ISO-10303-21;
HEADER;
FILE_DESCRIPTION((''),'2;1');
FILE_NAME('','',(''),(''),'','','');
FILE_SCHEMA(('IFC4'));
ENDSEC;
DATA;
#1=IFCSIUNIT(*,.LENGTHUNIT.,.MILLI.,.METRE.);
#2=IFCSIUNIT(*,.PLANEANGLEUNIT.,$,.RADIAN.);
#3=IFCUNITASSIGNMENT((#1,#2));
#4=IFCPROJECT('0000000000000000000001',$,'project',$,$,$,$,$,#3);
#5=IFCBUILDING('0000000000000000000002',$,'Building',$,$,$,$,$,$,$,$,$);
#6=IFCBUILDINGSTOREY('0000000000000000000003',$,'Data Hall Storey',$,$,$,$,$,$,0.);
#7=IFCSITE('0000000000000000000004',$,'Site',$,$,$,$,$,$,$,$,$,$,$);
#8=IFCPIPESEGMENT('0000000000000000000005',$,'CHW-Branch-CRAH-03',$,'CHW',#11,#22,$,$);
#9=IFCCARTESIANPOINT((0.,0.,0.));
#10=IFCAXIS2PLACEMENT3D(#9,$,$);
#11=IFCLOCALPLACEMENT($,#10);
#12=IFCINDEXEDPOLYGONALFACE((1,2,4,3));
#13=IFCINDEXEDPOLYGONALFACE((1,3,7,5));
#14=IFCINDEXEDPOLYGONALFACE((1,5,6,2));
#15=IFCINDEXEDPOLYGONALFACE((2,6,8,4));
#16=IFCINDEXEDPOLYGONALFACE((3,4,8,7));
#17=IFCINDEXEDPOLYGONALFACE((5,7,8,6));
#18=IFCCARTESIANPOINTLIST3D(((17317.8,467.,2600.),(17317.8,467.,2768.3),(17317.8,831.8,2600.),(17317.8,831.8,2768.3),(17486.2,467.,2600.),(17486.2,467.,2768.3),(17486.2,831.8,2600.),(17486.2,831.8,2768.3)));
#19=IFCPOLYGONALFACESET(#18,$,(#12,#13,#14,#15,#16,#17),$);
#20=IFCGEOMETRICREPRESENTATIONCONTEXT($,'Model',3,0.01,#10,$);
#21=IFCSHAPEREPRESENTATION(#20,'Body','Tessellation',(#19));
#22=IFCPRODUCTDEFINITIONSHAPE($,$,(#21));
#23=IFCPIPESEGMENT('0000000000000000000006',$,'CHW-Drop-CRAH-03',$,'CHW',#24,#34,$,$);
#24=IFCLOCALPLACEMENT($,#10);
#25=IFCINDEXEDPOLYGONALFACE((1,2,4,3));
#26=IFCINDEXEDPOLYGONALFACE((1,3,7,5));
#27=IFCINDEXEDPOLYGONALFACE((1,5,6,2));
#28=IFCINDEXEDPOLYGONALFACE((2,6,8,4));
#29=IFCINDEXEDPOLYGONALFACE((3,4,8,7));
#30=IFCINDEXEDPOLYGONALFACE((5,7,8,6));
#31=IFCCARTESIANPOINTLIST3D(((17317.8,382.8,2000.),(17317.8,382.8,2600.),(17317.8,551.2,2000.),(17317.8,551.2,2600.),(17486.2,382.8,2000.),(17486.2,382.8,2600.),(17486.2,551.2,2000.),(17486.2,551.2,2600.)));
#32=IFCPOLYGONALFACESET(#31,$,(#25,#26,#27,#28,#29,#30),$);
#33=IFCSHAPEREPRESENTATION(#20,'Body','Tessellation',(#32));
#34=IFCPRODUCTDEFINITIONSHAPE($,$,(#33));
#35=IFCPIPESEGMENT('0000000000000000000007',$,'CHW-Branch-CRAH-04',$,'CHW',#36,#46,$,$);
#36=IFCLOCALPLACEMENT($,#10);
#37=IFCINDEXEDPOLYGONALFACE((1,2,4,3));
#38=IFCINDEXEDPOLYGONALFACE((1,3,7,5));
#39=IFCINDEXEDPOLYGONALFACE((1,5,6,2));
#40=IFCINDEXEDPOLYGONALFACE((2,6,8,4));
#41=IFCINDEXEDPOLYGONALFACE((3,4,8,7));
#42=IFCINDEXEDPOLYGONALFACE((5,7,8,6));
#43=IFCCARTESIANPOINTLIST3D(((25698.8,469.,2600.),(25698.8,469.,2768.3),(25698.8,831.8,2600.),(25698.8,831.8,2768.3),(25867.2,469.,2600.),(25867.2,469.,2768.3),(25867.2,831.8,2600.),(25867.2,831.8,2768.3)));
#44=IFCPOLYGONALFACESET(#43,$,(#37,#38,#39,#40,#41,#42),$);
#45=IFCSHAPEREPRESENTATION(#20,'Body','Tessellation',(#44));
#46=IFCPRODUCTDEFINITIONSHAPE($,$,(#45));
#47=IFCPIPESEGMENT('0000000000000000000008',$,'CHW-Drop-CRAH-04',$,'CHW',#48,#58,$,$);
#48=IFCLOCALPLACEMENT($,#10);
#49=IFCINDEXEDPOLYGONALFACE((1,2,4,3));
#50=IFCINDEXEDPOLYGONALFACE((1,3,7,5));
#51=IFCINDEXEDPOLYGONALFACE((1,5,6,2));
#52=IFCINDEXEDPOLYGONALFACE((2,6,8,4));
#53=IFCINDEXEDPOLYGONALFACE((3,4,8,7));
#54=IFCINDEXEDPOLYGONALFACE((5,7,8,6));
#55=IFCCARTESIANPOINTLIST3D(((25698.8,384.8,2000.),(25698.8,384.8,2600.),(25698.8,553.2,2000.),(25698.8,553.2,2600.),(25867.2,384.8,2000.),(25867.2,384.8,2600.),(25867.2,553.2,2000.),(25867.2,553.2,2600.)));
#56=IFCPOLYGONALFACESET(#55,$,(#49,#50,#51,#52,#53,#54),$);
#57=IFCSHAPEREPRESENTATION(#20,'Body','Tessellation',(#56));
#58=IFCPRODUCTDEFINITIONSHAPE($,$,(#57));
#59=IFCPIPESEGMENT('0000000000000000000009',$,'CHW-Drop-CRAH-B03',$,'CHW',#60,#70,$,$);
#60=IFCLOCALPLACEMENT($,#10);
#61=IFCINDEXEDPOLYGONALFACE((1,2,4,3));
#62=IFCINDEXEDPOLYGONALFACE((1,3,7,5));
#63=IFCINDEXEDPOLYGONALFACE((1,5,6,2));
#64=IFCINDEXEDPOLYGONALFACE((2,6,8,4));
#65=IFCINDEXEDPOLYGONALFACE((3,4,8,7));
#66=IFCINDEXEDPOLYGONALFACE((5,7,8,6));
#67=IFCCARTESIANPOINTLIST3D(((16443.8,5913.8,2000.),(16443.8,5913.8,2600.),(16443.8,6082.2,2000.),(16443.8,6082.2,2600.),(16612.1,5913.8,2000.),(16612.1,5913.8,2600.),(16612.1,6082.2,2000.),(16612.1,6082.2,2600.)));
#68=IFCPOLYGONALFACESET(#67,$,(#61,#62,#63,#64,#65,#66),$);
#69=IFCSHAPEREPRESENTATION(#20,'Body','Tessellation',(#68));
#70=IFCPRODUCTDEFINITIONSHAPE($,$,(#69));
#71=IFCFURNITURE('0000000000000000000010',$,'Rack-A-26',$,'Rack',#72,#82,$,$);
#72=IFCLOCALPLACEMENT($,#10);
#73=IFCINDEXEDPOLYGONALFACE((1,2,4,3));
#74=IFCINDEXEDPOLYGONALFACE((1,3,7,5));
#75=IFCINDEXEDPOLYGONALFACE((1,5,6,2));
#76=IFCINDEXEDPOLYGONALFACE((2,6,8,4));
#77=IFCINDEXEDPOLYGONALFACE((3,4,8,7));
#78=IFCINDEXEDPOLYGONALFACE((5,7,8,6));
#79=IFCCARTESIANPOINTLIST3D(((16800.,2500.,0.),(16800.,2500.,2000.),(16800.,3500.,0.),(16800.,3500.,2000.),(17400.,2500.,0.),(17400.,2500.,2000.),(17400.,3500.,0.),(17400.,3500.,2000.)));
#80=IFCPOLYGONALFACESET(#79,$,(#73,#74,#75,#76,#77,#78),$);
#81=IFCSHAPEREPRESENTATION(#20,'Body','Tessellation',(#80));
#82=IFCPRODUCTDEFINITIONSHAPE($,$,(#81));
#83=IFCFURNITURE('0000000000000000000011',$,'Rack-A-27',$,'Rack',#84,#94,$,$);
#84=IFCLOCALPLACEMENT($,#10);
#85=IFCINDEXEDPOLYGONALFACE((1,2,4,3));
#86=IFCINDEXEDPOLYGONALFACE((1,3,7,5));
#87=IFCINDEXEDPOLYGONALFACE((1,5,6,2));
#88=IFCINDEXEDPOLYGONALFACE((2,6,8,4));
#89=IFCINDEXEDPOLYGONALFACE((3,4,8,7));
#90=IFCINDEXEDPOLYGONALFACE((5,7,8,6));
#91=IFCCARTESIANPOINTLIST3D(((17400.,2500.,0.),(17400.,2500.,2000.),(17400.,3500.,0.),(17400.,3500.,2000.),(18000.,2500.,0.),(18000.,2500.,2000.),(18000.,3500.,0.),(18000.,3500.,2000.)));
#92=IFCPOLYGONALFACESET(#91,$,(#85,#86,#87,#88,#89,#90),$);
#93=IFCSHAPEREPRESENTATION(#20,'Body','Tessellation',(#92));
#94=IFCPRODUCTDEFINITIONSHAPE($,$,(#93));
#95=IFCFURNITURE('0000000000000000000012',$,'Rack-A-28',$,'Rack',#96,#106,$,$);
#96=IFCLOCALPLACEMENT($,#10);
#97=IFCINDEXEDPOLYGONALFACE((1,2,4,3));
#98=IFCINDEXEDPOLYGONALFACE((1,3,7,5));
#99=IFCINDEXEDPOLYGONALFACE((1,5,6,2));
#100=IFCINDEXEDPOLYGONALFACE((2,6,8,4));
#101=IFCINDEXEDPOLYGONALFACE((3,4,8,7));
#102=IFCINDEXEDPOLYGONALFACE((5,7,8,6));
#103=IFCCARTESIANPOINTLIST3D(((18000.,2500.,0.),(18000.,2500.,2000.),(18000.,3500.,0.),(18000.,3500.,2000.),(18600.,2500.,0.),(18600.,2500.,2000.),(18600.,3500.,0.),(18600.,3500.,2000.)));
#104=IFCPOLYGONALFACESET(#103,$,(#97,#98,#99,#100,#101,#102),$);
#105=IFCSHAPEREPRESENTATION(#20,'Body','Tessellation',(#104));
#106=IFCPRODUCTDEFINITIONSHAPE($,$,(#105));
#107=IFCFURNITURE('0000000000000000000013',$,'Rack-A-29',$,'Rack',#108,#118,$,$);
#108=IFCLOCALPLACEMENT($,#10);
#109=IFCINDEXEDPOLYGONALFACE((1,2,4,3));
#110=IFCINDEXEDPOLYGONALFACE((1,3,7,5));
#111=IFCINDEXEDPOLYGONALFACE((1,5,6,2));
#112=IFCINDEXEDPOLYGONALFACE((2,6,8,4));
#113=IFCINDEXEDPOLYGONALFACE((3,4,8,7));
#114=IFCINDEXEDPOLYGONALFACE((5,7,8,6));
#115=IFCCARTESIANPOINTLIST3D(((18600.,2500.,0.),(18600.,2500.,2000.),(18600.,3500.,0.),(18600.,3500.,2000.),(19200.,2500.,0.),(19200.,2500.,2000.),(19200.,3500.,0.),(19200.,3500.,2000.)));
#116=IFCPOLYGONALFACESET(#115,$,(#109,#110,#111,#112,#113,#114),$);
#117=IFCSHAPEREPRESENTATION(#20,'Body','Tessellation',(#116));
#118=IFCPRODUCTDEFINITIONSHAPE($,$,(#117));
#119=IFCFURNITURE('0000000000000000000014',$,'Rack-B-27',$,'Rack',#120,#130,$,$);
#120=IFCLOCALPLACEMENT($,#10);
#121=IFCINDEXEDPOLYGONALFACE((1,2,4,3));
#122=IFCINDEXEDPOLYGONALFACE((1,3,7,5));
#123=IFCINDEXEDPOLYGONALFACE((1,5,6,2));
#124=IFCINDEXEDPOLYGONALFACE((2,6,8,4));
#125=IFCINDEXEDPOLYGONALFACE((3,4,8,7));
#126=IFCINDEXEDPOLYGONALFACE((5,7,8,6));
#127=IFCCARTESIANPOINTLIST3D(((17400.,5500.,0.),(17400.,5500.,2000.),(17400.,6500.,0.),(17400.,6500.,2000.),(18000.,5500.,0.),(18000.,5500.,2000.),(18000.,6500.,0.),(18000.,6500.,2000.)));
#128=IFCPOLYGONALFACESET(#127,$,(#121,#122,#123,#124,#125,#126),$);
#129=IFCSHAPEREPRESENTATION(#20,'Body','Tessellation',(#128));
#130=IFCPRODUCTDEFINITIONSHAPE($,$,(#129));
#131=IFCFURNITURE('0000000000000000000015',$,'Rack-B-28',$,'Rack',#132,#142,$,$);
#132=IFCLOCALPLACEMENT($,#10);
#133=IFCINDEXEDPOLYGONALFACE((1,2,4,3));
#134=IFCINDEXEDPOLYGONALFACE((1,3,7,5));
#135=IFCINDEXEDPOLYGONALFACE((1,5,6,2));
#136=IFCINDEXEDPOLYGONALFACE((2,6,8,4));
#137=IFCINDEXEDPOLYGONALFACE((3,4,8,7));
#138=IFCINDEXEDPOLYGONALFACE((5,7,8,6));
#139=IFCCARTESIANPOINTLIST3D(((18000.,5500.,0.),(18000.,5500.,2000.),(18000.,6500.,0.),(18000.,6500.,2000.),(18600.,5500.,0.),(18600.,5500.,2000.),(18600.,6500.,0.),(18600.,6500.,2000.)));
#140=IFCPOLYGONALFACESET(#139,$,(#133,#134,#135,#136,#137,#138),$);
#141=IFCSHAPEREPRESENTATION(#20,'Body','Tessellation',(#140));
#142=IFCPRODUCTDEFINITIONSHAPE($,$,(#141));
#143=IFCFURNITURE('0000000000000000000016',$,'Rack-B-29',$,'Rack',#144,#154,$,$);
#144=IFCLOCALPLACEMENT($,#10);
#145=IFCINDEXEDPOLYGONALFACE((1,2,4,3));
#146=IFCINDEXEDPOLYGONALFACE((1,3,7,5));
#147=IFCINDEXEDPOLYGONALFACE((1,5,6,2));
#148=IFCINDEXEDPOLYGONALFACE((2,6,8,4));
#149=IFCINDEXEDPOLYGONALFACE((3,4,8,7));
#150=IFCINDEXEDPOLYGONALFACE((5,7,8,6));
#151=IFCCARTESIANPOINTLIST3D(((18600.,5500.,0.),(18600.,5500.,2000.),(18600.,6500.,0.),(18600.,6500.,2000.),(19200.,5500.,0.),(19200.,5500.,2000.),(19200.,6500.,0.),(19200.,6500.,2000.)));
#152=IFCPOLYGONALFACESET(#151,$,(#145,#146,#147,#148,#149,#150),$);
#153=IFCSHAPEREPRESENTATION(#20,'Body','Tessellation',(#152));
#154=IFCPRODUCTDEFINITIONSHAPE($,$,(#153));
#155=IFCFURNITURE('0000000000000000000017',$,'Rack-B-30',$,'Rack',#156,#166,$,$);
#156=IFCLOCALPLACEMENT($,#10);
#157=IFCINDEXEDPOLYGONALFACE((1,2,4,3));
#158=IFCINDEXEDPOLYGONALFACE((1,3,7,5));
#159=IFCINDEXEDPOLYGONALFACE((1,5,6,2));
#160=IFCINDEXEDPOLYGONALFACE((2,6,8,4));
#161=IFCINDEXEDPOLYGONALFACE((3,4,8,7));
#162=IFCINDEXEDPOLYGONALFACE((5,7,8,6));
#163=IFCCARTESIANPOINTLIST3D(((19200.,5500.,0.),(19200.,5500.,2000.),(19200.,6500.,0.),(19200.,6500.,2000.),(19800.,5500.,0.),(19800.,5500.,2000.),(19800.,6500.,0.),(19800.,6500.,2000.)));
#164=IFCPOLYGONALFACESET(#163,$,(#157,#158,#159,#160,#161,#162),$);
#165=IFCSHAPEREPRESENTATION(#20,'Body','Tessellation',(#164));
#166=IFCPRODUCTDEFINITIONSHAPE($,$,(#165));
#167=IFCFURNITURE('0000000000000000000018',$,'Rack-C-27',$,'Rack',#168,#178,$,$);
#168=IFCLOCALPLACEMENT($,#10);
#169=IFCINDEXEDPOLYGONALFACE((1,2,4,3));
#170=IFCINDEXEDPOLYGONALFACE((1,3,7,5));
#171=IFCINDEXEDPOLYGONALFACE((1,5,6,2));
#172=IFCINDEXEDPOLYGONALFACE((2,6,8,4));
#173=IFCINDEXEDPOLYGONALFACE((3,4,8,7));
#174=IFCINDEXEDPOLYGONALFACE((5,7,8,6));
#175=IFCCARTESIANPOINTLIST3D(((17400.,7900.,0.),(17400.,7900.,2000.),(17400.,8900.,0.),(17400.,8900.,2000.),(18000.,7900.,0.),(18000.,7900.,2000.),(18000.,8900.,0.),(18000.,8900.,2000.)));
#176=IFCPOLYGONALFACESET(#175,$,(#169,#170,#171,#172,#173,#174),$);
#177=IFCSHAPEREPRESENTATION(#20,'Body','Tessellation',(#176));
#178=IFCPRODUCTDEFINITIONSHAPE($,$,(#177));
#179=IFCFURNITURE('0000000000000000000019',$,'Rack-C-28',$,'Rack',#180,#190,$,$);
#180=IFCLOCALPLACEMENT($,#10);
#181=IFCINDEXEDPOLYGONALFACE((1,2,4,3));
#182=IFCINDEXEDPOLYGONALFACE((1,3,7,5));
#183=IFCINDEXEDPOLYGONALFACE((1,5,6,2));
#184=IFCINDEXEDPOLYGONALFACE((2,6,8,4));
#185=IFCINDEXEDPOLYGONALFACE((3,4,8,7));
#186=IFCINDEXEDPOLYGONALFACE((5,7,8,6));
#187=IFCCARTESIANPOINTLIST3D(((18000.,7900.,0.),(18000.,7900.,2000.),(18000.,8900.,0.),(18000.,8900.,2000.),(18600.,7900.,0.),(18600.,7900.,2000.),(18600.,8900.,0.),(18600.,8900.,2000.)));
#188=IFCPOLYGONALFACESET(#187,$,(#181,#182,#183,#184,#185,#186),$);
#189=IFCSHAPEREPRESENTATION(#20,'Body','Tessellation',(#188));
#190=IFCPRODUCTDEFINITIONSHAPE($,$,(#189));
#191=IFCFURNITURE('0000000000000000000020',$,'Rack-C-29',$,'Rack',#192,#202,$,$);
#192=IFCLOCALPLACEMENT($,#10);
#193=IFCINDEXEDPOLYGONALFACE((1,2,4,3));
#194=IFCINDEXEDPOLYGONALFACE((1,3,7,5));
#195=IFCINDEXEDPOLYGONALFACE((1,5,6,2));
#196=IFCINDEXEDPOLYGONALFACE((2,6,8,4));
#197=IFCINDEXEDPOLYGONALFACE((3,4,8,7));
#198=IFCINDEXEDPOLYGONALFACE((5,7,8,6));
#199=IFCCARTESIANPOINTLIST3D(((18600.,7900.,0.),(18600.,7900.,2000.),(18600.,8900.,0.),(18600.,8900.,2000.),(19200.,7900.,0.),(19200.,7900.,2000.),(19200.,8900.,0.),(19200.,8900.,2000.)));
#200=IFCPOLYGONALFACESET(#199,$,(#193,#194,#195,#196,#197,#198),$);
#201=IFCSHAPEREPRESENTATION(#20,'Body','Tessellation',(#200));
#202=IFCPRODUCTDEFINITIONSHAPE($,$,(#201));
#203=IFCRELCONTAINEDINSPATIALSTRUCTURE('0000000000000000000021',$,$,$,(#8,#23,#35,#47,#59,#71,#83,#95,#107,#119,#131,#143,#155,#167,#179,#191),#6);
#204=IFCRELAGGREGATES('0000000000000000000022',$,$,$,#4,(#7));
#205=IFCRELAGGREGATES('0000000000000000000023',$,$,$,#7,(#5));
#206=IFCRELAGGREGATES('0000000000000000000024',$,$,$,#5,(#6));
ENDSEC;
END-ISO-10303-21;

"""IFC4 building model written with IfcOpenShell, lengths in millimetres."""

from ifc_helpers import new_model, si_unit, frame, origin, place, context, project, spatial, rectangle, extrude, element, save


model = new_model("IFC4")

# Units and contexts
model_context = context("Model", 3, precision=0.01, world=origin())
ifc_project = project(units=[si_unit("LENGTHUNIT", "METRE", prefix="MILLI"), si_unit("PLANEANGLEUNIT", "RADIAN")])

# Site, building, storey
site = spatial("IfcSite", under=ifc_project, Name="Site")
building = spatial("IfcBuilding", under=site, Name="Building")
storey = spatial("IfcBuildingStorey", under=building, Name="Data Hall Storey", Elevation=0.0)

# Pipe segments
pipe_segment_1_placement = place(None, frame((17402.0, 649.4, 2600.0)))
element("IfcPipeSegment", 1, at=pipe_segment_1_placement, inside=storey, Name="CHW-Branch-CRAH-03", ObjectType="CHW", context=model_context, shape_type="SweptSolid", body=[
    extrude(rectangle(XDim=168.3, YDim=364.9), origin(), (0.0, 0.0, 1.0), 168.3),
])
pipe_segment_2_placement = place(None, frame((17402.0, 467.0, 2000.0)))
element("IfcPipeSegment", 2, at=pipe_segment_2_placement, inside=storey, Name="CHW-Drop-CRAH-03", ObjectType="CHW", context=model_context, shape_type="SweptSolid", body=[
    extrude(rectangle(XDim=168.3, YDim=168.3), origin(), (0.0, 0.0, 1.0), 600.0),
])
pipe_segment_3_placement = place(None, frame((25783.0, 650.4, 2600.0)))
element("IfcPipeSegment", 3, at=pipe_segment_3_placement, inside=storey, Name="CHW-Branch-CRAH-04", ObjectType="CHW", context=model_context, shape_type="SweptSolid", body=[
    extrude(rectangle(XDim=168.3, YDim=362.9), origin(), (0.0, 0.0, 1.0), 168.3),
])
for number, where, name in (
    (4, (25783.0, 469.0, 2000.0), "CHW-Drop-CRAH-04"),
    (5, (16528.0, 5998.0, 2000.0), "CHW-Drop-CRAH-B03"),
):
    element("IfcPipeSegment", number, at=place(None, frame(where)), inside=storey, Name=name, ObjectType="CHW", context=model_context, shape_type="SweptSolid", body=[
        extrude(rectangle(XDim=168.3, YDim=168.3), origin(), (0.0, 0.0, 1.0), 600.0),
    ])

# Furniture
for number, where, name in (
    (6, (17100.0, 3000.0, 0.0), "Rack-A-26"),
    (7, (17700.0, 3000.0, 0.0), "Rack-A-27"),
    (8, (18300.0, 3000.0, 0.0), "Rack-A-28"),
    (9, (18900.0, 3000.0, 0.0), "Rack-A-29"),
    (10, (17700.0, 6000.0, 0.0), "Rack-B-27"),
    (11, (18300.0, 6000.0, 0.0), "Rack-B-28"),
    (12, (18900.0, 6000.0, 0.0), "Rack-B-29"),
    (13, (19500.0, 6000.0, 0.0), "Rack-B-30"),
    (14, (17700.0, 8400.0, 0.0), "Rack-C-27"),
    (15, (18300.0, 8400.0, 0.0), "Rack-C-28"),
    (16, (18900.0, 8400.0, 0.0), "Rack-C-29"),
):
    element("IfcFurniture", number, at=place(None, frame(where)), inside=storey, Name=name, ObjectType="Rack", context=model_context, shape_type="SweptSolid", body=[
        extrude(rectangle(XDim=600.0, YDim=1000.0), origin(), (0.0, 0.0, 1.0), 2000.0),
    ])

save(model, "model.ifc")
